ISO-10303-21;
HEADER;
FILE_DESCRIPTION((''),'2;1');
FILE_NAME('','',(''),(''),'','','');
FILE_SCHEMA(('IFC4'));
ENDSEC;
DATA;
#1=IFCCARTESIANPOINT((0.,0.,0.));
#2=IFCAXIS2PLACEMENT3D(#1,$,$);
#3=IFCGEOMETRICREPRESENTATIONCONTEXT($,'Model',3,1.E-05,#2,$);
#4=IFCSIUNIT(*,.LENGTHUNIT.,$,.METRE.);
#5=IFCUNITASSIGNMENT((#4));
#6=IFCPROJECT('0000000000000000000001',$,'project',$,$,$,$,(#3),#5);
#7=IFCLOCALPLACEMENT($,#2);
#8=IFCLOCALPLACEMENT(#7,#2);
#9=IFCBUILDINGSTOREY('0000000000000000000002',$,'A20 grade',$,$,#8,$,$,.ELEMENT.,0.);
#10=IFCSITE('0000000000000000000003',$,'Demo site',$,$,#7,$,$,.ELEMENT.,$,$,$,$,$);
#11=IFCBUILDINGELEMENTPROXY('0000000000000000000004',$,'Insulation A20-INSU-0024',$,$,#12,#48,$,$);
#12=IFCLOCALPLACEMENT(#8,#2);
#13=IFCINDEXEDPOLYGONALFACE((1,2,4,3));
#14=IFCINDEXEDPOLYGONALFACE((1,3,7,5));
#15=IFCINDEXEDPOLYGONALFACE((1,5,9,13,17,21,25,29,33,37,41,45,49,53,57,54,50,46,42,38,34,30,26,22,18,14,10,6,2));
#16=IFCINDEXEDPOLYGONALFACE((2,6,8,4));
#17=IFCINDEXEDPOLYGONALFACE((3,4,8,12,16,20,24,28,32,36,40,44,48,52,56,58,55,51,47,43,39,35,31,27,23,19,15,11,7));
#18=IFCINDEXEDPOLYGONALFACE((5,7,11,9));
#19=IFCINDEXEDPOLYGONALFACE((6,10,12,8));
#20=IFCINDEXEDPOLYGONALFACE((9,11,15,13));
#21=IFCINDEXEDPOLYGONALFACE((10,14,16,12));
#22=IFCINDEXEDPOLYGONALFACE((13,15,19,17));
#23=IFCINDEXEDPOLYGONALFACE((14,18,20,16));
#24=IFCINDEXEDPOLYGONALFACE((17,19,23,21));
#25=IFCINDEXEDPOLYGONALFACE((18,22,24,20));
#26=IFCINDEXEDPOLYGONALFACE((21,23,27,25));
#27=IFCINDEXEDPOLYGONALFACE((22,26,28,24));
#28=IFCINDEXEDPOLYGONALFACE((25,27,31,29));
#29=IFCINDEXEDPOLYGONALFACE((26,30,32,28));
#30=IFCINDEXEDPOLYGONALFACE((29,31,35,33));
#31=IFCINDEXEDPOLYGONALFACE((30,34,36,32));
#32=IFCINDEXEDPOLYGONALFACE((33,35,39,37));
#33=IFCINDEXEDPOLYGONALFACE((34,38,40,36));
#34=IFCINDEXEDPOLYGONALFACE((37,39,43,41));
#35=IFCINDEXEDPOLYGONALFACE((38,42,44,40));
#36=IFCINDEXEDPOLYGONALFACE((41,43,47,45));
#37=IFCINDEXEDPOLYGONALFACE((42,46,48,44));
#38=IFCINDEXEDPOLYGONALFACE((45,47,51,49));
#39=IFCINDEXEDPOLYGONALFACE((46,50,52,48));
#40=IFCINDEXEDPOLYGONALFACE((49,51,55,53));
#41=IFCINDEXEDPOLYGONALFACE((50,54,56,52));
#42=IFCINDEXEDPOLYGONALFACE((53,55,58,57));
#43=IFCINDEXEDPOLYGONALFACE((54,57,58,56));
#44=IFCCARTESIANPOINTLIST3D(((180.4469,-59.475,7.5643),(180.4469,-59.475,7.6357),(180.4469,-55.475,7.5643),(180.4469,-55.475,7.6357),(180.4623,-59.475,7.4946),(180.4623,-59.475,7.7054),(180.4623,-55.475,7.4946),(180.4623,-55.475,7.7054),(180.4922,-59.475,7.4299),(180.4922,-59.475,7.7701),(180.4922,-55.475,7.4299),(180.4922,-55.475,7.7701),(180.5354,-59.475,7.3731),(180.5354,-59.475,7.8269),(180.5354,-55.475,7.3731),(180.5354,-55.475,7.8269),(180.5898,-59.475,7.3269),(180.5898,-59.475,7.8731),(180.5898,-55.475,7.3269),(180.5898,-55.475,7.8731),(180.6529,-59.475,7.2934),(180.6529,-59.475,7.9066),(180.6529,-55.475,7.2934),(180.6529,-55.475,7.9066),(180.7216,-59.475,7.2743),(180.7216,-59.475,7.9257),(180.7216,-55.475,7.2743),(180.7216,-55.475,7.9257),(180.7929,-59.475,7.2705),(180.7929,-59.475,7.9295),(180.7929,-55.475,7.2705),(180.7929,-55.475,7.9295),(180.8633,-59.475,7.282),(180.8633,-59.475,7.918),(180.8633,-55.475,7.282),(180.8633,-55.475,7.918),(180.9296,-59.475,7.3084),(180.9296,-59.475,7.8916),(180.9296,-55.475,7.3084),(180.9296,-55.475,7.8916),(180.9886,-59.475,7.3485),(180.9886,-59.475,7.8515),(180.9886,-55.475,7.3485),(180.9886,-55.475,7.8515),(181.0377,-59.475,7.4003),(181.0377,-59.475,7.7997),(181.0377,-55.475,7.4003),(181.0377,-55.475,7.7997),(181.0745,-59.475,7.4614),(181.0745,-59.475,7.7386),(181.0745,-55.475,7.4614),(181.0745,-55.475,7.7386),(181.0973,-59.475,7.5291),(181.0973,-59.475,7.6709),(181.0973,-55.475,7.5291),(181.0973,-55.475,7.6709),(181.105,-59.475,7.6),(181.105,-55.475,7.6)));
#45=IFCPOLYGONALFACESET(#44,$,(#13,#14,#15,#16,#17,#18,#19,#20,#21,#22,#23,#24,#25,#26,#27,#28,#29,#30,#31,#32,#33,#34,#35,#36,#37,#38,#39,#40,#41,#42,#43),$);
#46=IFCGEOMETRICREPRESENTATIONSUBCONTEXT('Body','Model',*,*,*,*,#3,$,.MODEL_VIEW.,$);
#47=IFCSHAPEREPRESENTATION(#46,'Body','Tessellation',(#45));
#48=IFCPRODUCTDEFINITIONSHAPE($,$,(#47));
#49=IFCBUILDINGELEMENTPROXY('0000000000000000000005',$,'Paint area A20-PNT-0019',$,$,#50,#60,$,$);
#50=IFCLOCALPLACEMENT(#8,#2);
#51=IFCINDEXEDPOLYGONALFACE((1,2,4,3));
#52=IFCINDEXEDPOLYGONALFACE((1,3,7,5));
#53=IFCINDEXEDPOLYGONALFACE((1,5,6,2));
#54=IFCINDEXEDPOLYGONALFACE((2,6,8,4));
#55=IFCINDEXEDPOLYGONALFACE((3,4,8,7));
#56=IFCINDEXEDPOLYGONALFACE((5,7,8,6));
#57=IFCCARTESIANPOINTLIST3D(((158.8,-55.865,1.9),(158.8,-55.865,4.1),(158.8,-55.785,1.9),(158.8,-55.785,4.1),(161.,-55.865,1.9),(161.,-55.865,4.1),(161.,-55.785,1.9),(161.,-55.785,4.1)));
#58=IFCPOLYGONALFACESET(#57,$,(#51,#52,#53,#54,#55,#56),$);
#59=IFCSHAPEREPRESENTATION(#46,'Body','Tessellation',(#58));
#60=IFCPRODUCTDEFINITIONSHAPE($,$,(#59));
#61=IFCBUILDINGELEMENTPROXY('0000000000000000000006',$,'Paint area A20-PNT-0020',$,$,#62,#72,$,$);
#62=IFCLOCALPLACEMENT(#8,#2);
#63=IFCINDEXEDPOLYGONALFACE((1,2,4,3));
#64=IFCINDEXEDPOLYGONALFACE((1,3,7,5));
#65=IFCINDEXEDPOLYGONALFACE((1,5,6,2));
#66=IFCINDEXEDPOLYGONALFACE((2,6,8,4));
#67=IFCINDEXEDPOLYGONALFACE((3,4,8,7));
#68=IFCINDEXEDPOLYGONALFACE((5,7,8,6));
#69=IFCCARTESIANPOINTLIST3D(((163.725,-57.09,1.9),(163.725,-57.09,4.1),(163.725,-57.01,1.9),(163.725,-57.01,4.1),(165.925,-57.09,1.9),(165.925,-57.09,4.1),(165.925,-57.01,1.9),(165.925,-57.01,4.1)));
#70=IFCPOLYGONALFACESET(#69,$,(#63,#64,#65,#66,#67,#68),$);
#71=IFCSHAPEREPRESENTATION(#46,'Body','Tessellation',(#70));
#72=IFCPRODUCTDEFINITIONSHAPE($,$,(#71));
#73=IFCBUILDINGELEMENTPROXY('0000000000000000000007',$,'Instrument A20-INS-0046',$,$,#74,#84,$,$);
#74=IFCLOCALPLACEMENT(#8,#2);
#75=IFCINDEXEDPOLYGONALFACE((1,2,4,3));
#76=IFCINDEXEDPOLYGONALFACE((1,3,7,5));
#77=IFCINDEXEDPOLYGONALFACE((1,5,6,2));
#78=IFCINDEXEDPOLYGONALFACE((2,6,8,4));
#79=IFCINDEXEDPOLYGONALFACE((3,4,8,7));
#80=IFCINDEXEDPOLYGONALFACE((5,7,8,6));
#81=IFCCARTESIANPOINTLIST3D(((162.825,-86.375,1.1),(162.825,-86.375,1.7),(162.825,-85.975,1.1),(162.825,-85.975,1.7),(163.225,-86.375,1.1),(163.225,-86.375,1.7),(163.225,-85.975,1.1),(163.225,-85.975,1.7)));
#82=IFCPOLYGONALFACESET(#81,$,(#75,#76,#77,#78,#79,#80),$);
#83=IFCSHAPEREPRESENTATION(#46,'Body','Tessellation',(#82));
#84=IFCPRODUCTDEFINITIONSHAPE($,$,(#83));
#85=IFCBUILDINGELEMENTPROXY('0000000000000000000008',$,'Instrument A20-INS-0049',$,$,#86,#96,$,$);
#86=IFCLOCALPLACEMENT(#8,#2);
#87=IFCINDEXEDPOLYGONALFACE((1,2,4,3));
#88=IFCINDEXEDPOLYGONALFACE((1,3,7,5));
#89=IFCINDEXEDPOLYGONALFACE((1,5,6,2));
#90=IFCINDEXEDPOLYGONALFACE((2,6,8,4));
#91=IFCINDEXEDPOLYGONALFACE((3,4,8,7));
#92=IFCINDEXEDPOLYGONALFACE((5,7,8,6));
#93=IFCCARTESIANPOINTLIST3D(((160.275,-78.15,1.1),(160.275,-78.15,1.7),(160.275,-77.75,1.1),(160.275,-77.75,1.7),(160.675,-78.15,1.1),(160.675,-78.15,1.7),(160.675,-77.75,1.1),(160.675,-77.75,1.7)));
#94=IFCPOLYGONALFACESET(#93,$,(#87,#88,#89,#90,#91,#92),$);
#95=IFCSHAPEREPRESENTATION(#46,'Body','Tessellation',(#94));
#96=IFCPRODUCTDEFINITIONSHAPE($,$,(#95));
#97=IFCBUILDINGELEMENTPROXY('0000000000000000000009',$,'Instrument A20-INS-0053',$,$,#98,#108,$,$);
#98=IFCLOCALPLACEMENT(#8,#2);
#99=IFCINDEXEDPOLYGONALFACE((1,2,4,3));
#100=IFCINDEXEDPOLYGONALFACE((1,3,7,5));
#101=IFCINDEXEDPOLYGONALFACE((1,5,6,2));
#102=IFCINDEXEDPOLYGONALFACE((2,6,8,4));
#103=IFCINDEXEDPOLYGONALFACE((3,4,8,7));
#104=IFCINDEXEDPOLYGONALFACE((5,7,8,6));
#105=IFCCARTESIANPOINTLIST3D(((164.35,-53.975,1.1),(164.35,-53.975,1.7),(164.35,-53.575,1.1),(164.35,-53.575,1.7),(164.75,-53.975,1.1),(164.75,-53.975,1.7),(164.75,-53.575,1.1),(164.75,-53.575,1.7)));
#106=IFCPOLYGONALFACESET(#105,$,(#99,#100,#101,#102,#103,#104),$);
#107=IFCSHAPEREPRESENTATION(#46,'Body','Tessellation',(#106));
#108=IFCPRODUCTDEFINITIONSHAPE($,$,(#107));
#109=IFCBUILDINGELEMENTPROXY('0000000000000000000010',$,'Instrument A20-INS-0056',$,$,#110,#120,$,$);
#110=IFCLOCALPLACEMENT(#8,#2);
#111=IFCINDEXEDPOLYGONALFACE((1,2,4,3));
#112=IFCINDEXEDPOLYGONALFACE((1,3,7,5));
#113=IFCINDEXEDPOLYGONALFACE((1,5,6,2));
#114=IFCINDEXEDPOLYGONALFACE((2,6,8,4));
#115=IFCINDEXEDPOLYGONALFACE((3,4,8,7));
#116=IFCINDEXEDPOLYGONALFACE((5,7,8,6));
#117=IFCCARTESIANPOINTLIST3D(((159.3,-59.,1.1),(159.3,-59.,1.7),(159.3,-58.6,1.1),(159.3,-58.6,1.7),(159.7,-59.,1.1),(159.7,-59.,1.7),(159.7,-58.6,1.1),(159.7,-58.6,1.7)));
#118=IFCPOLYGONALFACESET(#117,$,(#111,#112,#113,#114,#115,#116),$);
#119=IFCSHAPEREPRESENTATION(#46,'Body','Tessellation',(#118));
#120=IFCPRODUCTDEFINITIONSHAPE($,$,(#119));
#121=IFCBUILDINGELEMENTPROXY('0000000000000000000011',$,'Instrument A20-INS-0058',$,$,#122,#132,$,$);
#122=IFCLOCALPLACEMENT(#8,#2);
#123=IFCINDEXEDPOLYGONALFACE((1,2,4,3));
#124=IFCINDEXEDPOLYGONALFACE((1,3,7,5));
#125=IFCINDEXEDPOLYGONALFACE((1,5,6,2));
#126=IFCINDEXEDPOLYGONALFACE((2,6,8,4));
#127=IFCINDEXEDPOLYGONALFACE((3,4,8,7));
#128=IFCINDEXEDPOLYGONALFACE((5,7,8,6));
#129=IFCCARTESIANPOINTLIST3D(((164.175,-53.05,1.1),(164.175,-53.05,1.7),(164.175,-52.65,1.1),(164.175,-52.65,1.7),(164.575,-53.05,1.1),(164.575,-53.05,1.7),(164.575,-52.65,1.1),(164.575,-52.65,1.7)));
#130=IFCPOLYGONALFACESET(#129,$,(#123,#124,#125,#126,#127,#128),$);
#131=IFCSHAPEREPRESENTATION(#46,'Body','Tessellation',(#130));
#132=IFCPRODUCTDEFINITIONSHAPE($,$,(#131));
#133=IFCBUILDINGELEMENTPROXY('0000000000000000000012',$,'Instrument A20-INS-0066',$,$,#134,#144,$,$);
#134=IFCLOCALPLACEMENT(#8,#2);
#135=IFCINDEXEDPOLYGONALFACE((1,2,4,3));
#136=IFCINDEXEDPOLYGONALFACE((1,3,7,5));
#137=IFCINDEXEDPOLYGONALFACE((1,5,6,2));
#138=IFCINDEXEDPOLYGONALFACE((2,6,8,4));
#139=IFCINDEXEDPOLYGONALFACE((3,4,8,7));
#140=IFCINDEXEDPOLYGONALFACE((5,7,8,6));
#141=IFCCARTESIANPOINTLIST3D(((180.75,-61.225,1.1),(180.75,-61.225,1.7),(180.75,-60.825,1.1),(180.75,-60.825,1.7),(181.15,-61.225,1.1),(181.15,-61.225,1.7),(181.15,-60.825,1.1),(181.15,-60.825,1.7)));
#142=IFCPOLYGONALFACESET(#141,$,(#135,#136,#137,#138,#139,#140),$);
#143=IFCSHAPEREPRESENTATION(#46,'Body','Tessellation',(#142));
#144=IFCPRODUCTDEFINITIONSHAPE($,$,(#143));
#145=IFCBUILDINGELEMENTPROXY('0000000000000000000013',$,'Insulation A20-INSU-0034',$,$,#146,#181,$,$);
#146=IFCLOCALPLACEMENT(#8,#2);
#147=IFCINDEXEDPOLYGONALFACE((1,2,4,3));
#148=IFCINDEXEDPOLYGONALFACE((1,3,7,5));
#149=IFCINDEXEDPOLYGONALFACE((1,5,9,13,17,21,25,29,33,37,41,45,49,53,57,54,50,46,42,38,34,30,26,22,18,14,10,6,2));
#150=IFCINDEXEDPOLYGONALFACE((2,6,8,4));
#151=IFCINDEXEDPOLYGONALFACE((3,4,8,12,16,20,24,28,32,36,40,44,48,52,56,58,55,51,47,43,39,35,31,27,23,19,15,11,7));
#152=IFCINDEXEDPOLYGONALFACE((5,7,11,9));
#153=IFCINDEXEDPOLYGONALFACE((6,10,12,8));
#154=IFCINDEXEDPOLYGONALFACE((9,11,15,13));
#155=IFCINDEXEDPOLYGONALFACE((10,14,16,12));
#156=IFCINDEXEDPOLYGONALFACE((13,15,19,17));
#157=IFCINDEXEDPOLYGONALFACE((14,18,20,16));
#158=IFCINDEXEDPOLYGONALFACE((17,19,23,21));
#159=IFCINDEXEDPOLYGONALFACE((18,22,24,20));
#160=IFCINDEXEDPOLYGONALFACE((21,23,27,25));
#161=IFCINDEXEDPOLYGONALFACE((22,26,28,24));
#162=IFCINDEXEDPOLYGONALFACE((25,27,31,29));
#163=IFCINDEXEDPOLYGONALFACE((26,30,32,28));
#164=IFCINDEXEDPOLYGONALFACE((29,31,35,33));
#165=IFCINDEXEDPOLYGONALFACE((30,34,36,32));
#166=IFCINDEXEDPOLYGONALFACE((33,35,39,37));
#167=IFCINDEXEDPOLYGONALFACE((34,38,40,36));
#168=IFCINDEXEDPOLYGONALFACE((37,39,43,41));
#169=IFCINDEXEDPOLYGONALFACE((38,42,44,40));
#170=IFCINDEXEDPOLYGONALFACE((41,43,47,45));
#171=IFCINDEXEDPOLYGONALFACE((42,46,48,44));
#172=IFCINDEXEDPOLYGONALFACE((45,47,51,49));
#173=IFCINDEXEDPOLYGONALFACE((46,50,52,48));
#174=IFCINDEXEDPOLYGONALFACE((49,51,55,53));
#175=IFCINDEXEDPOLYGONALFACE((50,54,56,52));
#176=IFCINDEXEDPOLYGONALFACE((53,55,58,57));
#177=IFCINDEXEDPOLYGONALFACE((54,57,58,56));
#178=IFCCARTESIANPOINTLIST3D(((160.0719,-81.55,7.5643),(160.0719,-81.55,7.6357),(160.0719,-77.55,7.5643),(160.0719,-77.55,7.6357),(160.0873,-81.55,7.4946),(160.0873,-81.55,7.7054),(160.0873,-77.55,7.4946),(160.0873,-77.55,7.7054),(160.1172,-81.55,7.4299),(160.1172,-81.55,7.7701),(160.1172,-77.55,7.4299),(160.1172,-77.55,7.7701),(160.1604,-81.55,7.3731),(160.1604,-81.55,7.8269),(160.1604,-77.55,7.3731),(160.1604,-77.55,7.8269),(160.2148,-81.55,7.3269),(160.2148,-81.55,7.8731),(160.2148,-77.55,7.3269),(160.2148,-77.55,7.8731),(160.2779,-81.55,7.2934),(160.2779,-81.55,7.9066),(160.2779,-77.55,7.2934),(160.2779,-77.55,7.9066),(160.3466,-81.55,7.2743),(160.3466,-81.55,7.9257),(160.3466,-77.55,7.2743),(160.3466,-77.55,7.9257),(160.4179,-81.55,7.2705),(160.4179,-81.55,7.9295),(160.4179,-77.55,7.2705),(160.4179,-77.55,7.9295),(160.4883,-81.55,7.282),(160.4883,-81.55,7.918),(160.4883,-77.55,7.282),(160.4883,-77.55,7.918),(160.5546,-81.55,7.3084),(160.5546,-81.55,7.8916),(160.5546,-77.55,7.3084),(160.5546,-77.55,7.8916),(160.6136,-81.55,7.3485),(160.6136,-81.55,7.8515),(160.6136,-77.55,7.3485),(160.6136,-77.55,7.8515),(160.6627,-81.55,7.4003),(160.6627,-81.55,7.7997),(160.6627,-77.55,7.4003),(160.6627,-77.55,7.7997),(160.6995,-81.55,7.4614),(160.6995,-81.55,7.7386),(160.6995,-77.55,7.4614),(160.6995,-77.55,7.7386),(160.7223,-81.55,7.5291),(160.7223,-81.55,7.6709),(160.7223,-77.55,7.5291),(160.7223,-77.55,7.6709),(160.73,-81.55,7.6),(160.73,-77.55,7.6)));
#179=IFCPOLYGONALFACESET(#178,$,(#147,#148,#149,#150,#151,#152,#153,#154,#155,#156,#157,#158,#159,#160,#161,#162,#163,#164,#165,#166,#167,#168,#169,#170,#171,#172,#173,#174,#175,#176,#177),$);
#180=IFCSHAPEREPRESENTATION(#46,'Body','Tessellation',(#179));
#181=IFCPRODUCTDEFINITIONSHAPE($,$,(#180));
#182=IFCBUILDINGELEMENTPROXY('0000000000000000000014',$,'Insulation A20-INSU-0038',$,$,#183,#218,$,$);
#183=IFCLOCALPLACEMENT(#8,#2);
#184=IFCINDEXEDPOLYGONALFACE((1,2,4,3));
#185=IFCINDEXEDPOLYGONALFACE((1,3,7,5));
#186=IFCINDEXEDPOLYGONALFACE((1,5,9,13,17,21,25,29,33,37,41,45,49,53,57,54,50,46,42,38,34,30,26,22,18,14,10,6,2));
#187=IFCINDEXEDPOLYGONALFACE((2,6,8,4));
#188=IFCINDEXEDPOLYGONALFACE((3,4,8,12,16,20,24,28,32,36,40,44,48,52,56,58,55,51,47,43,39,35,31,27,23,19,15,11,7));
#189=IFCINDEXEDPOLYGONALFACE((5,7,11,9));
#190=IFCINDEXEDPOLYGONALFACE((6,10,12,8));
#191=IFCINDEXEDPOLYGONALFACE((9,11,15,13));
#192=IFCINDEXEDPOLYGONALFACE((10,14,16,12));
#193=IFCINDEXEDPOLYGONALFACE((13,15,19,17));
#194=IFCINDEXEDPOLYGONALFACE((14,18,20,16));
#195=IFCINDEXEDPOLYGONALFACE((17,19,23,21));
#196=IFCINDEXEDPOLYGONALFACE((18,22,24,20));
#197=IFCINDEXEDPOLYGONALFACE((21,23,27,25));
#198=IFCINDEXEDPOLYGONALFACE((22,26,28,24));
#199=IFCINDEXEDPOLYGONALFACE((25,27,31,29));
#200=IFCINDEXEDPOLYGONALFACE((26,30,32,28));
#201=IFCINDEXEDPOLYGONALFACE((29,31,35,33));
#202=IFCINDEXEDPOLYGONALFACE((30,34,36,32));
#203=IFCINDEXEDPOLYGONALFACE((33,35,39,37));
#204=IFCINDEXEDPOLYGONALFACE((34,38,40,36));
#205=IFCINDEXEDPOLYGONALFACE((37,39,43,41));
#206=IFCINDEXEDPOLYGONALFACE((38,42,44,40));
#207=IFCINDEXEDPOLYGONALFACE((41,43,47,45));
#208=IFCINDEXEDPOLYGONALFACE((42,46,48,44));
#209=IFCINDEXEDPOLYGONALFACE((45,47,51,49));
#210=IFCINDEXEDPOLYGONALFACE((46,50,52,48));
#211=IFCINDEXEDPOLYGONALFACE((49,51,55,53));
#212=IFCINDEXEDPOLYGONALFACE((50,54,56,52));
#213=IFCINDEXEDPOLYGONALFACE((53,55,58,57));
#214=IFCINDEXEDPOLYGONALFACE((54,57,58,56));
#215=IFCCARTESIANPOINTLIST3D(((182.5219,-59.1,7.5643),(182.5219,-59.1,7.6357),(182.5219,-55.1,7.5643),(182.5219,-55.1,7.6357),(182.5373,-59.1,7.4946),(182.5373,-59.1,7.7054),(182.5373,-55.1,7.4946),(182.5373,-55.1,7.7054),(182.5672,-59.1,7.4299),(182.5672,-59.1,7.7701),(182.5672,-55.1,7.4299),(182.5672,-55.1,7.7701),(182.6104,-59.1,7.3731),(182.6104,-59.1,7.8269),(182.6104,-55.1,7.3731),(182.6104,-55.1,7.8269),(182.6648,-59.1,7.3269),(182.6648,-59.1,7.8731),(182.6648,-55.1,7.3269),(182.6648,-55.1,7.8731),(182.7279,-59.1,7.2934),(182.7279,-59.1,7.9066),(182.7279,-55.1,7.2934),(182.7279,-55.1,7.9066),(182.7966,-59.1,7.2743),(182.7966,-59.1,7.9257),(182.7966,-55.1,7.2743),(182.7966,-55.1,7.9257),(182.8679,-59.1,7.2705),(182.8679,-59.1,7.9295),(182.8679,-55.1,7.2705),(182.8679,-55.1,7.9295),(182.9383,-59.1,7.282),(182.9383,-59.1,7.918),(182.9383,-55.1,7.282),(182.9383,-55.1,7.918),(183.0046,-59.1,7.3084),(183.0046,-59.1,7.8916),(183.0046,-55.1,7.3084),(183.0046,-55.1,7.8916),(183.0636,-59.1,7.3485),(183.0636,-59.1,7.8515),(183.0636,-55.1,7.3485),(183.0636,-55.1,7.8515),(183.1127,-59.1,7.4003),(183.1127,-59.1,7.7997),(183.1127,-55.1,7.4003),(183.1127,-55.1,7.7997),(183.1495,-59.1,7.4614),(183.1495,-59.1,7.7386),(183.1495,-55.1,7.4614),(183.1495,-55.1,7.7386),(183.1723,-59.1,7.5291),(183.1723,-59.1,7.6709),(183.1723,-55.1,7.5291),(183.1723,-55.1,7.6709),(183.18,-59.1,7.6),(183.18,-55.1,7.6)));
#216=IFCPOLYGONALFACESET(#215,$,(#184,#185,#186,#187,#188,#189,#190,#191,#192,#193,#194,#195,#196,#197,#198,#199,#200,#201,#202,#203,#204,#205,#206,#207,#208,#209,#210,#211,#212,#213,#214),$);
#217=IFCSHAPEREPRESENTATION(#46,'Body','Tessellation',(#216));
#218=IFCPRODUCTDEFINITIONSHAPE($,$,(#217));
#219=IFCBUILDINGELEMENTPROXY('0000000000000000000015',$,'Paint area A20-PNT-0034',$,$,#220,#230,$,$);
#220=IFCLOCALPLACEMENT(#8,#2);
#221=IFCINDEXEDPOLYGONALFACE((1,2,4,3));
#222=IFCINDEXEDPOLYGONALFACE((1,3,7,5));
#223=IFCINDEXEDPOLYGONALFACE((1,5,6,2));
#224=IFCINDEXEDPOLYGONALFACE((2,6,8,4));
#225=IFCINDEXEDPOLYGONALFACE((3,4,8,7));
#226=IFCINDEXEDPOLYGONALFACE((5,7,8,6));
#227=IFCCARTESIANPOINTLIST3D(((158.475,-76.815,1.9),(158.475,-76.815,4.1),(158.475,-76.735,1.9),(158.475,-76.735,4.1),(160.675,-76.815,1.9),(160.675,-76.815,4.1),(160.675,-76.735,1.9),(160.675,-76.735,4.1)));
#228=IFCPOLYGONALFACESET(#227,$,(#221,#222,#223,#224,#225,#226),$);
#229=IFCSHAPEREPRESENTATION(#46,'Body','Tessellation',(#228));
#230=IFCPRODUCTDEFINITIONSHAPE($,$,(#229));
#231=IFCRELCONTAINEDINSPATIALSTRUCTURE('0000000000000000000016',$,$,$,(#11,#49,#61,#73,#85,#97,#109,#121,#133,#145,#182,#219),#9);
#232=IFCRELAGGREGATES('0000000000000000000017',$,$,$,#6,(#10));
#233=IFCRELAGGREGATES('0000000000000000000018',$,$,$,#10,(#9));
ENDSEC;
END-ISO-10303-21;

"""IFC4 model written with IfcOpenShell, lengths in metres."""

from ifc_helpers import new_model, si_unit, frame, origin, place, context, subcontext, project, spatial, rectangle, circle, extrude, element, save


model = new_model("IFC4")

# Units and contexts
model_context = context("Model", 3, precision=1e-05, world=origin())
body_context = subcontext(model_context, "Body", "Model", "MODEL_VIEW")
ifc_project = project(units=[si_unit("LENGTHUNIT", "METRE")], contexts=[model_context])

# Site, storey
site_placement = place(None, origin())
site = spatial("IfcSite", under=ifc_project, at=site_placement, Name="Demo site", CompositionType="ELEMENT")
storey_placement = place(site_placement, origin())
storey = spatial("IfcBuildingStorey", under=site, at=storey_placement, Name="A20 grade", CompositionType="ELEMENT", Elevation=0.0)

# Building element proxies
for number, where, name in (
    (1, (180.775, -59.475, 7.6), "Insulation A20-INSU-0024"),
):
    element("IfcBuildingElementProxy", number, at=place(storey_placement, frame(where)), inside=storey, Name=name, context=body_context, shape_type="SweptSolid", body=[
        extrude(circle(Radius=0.33), frame((0.0, 0.0, 0.0), z_axis=(0.0, 1.0, 0.0), x_axis=(1.0, 0.0, 0.0)), (0.0, 0.0, 1.0), 4.0),
    ])
for number, where, name in (
    (2, (159.9, -55.825, 1.9), "Paint area A20-PNT-0019"),
    (3, (164.825, -57.05, 1.9), "Paint area A20-PNT-0020"),
):
    element("IfcBuildingElementProxy", number, at=place(storey_placement, frame(where)), inside=storey, Name=name, context=body_context, shape_type="SweptSolid", body=[
        extrude(rectangle(XDim=2.2, YDim=0.08), origin(), (0.0, 0.0, 1.0), 2.2),
    ])
for number, where, name in (
    (4, (163.025, -86.175, 1.1), "Instrument A20-INS-0046"),
    (5, (160.475, -77.95, 1.1), "Instrument A20-INS-0049"),
    (6, (164.55, -53.775, 1.1), "Instrument A20-INS-0053"),
    (7, (159.5, -58.8, 1.1), "Instrument A20-INS-0056"),
    (8, (164.375, -52.85, 1.1), "Instrument A20-INS-0058"),
    (9, (180.95, -61.025, 1.1), "Instrument A20-INS-0066"),
):
    element("IfcBuildingElementProxy", number, at=place(storey_placement, frame(where)), inside=storey, Name=name, context=body_context, shape_type="SweptSolid", body=[
        extrude(rectangle(XDim=0.4, YDim=0.4), origin(), (0.0, 0.0, 1.0), 0.6),
    ])
for number, where, name in (
    (10, (160.4, -81.55, 7.6), "Insulation A20-INSU-0034"),
    (11, (182.85, -59.1, 7.6), "Insulation A20-INSU-0038"),
):
    element("IfcBuildingElementProxy", number, at=place(storey_placement, frame(where)), inside=storey, Name=name, context=body_context, shape_type="SweptSolid", body=[
        extrude(circle(Radius=0.33), frame((0.0, 0.0, 0.0), z_axis=(0.0, 1.0, 0.0), x_axis=(1.0, 0.0, 0.0)), (0.0, 0.0, 1.0), 4.0),
    ])
for number, where, name in (
    (12, (159.575, -76.775, 1.9), "Paint area A20-PNT-0034"),
):
    element("IfcBuildingElementProxy", number, at=place(storey_placement, frame(where)), inside=storey, Name=name, context=body_context, shape_type="SweptSolid", body=[
        extrude(rectangle(XDim=2.2, YDim=0.08), origin(), (0.0, 0.0, 1.0), 2.2),
    ])

save(model, "model.ifc")
